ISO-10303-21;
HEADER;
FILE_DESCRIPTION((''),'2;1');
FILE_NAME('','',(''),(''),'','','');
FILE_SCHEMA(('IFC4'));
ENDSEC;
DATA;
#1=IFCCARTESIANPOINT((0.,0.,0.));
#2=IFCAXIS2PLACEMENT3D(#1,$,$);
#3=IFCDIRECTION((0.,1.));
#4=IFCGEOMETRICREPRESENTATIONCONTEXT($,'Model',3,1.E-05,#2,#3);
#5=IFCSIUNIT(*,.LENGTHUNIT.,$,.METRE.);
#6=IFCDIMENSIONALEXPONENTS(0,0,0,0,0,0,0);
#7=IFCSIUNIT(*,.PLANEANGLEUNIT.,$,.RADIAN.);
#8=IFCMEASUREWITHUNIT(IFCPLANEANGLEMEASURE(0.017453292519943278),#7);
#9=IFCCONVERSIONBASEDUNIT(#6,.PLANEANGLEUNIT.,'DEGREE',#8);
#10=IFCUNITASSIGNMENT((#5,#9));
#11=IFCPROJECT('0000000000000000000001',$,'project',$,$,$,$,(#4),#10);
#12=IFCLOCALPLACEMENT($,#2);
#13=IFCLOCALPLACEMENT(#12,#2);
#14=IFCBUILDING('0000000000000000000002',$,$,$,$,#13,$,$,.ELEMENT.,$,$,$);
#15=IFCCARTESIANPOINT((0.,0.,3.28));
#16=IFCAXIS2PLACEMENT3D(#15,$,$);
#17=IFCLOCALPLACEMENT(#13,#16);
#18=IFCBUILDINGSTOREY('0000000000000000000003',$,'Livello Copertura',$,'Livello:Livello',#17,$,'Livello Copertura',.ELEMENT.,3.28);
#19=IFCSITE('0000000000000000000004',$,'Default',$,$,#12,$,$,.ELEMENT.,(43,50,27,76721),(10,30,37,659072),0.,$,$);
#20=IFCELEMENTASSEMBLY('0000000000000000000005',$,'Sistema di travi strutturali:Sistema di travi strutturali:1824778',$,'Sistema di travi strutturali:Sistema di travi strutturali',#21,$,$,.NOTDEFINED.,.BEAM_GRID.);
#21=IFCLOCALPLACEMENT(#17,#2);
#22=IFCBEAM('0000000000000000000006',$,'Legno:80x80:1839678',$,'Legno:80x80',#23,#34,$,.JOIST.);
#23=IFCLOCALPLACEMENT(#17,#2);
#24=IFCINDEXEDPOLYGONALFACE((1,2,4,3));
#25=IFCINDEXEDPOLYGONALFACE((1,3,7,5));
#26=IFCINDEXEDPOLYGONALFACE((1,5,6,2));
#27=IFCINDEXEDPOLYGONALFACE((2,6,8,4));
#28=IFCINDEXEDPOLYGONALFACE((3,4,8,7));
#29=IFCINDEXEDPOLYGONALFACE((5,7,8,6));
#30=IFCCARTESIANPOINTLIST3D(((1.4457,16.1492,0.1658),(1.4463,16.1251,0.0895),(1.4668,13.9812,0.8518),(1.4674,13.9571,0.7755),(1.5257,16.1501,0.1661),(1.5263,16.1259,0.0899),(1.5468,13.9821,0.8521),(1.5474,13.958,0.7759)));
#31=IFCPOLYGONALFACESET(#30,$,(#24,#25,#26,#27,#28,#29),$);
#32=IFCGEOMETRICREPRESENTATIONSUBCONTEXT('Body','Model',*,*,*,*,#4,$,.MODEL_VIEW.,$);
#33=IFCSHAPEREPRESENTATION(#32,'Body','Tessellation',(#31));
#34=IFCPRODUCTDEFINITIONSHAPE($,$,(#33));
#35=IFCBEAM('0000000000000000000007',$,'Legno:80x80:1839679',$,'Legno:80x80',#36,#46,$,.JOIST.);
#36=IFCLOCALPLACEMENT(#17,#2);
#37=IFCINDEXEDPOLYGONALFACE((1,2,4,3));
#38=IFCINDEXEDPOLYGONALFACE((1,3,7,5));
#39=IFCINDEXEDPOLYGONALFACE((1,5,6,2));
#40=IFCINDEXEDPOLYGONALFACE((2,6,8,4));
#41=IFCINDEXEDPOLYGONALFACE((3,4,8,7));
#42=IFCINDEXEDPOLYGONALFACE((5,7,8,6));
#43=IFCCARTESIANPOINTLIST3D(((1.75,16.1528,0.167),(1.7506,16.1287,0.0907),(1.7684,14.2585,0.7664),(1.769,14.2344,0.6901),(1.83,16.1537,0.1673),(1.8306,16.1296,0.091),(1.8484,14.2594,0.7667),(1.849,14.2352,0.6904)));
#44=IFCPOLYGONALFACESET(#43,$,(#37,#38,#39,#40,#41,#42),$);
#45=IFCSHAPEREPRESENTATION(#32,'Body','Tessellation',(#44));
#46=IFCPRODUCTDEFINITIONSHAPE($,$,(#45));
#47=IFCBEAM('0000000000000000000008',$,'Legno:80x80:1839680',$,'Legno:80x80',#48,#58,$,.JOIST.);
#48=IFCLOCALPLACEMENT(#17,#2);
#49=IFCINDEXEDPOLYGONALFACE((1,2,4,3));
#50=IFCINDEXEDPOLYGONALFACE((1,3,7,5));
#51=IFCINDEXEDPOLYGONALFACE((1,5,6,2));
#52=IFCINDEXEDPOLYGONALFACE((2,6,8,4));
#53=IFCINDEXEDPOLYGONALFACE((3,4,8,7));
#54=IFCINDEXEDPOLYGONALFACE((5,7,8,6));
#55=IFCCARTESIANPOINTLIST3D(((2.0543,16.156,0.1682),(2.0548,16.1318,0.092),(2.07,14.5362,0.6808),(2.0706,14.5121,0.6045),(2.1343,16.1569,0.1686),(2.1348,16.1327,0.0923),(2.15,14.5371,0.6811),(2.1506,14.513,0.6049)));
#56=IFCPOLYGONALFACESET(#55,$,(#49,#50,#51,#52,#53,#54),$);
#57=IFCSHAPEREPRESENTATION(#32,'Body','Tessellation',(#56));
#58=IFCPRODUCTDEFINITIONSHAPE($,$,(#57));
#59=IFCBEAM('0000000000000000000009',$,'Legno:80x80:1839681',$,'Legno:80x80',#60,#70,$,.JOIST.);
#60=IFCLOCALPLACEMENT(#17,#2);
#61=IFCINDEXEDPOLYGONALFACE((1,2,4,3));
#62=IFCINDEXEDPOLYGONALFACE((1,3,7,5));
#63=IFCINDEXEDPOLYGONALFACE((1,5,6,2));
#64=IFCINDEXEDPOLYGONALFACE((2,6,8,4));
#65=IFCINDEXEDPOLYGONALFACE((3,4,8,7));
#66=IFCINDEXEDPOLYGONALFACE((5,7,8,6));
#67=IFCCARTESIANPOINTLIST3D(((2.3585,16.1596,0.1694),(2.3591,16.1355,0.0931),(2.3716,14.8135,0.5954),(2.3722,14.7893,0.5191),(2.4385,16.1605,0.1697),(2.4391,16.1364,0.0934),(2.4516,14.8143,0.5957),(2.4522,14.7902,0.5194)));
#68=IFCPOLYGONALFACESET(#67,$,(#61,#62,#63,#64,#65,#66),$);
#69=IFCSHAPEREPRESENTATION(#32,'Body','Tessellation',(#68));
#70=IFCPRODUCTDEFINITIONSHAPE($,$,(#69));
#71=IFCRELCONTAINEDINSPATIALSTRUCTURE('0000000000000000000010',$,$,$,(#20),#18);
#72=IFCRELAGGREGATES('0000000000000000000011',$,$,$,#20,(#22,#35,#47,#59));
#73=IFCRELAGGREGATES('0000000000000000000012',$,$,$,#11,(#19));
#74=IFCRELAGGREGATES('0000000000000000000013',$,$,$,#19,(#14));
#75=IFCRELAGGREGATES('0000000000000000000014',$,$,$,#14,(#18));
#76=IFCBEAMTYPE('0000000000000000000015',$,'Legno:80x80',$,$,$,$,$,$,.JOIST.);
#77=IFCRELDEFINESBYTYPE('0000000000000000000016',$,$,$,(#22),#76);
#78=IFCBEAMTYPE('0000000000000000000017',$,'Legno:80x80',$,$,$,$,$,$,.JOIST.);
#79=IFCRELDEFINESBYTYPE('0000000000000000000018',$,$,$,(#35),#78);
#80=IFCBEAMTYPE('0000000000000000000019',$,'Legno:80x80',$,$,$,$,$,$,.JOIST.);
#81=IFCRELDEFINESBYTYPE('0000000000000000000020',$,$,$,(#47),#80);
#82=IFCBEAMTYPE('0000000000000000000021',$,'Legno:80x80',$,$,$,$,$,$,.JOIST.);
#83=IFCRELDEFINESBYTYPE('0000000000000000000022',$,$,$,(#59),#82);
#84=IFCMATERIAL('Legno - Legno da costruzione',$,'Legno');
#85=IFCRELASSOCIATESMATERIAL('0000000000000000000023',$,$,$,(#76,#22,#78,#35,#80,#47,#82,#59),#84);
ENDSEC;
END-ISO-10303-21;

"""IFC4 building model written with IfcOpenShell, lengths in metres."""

from ifc_helpers import new_model, entity, si_unit, converted_unit, direction, frame, origin, place, context, subcontext, project, spatial, indexed_curve, outline, extrude, source, transform, mapped, material, type_object, type_shapes, element, aggregate, save


model = new_model("IFC4")

# Units and contexts
model_context = context("Model", 3, precision=1e-05, world=origin(), true_north=direction((0.0, 1.0)))
body_context = subcontext(model_context, "Body", "Model", "MODEL_VIEW")
ifc_project = project(units=[si_unit("LENGTHUNIT", "METRE"), converted_unit("PLANEANGLEUNIT", "DEGREE", entity("IfcPlaneAngleMeasure", 0.017453292519943278), si_unit("PLANEANGLEUNIT", "RADIAN"), dimensions=[0, 0, 0, 0, 0, 0, 0])], contexts=[model_context])

# Site, building, storey
site_placement = place(None, origin())
site = spatial("IfcSite", under=ifc_project, at=site_placement, Name="Default", CompositionType="ELEMENT", RefLatitude=(43, 50, 27, 76721), RefLongitude=(10, 30, 37, 659072), RefElevation=0.0)
building_placement = place(site_placement, origin())
building = spatial("IfcBuilding", under=site, at=building_placement, CompositionType="ELEMENT")
storey_placement = place(building_placement, frame((0.0, 0.0, 3.28)))
storey = spatial("IfcBuildingStorey", under=building, at=storey_placement, Name="Livello Copertura", ObjectType="Livello:Livello", LongName="Livello Copertura", CompositionType="ELEMENT", Elevation=3.28)

# Shared definitions
ifc_material = material(Name="Legno - Legno da costruzione", Category="Legno")

# Element assembly, beams
assembly_1_placement = place(storey_placement, origin())
assembly_1 = element("IfcElementAssembly", 1, at=assembly_1_placement, inside=storey, Name="Sistema di travi strutturali:Sistema di travi strutturali:1824778", ObjectType="Sistema di travi strutturali:Sistema di travi strutturali", AssemblyPlace="NOTDEFINED", PredefinedType="BEAM_GRID")
beam_type_1 = type_object("IfcBeamType", Name="Legno:80x80", PredefinedType="JOIST", material=ifc_material)
shared_shape_1 = source(origin(), body_context, "Body", "SweptSolid", [
    extrude(outline(indexed_curve([(-1.137, -0.04), (1.137, -0.04), (1.137, 0.04), (-1.137, 0.04), (-1.137, -0.04)], self_intersect=False)), frame((0.0, 0.0, -0.04), z_axis=(0.0, 0.0, 1.0), x_axis=(-1.0, 0.0, 0.0)), (0.0, 0.0, 1.0), 0.08),
])
type_shapes(beam_type_1, [shared_shape_1])
beam_1_placement = place(assembly_1_placement, frame((1.4965, 15.0536, 0.4708), z_axis=(-0.007187, 0.301619, 0.953402), x_axis=(0.009277, -0.953365, 0.301677)))
beam_1 = element("IfcBeam", 2, at=beam_1_placement, type_object=beam_type_1, material=ifc_material, Name="Legno:80x80:1839678", ObjectType="Legno:80x80", PredefinedType="JOIST", context=body_context, shape_type="MappedRepresentation", body=[
    mapped(shared_shape_1, transform((0.0, 0.0, 0.0), scale=1.0)),
])
beam_type_2 = type_object("IfcBeamType", Name="Legno:80x80", PredefinedType="JOIST", material=ifc_material)
shared_shape_2 = source(origin(), body_context, "Body", "SweptSolid", [
    extrude(outline(indexed_curve([(-0.9935, -0.04), (0.9935, -0.04), (0.9935, 0.04), (-0.9935, 0.04), (-0.9935, -0.04)], self_intersect=False)), frame((0.0, 0.0, -0.04), z_axis=(0.0, 0.0, 1.0), x_axis=(-1.0, 0.0, 0.0)), (0.0, 0.0, 1.0), 0.08),
])
type_shapes(beam_type_2, [shared_shape_2])
beam_2_placement = place(assembly_1_placement, frame((1.7995, 15.194, 0.4287), z_axis=(-0.007187, 0.301619, 0.953402), x_axis=(0.009277, -0.953365, 0.301677)))
beam_2 = element("IfcBeam", 3, at=beam_2_placement, type_object=beam_type_2, material=ifc_material, Name="Legno:80x80:1839679", ObjectType="Legno:80x80", PredefinedType="JOIST", context=body_context, shape_type="MappedRepresentation", body=[
    mapped(shared_shape_2, transform((0.0, 0.0, 0.0), scale=1.0)),
])
beam_type_3 = type_object("IfcBeamType", Name="Legno:80x80", PredefinedType="JOIST", material=ifc_material)
shared_shape_3 = source(origin(), body_context, "Body", "SweptSolid", [
    extrude(outline(indexed_curve([(-0.8495, -0.04), (0.8495, -0.04), (0.8495, 0.04), (-0.8495, 0.04), (-0.8495, -0.04)], self_intersect=False)), frame((0.0, 0.0, -0.04), z_axis=(0.0, 0.0, 1.0), x_axis=(-1.0, 0.0, 0.0)), (0.0, 0.0, 1.0), 0.08),
])
type_shapes(beam_type_3, [shared_shape_3])
beam_3_placement = place(assembly_1_placement, frame((2.1024, 15.3345, 0.3865), z_axis=(-0.007187, 0.301619, 0.953402), x_axis=(0.009277, -0.953365, 0.301677)))
beam_3 = element("IfcBeam", 4, at=beam_3_placement, type_object=beam_type_3, material=ifc_material, Name="Legno:80x80:1839680", ObjectType="Legno:80x80", PredefinedType="JOIST", context=body_context, shape_type="MappedRepresentation", body=[
    mapped(shared_shape_3, transform((0.0, 0.0, 0.0), scale=1.0)),
])
beam_type_4 = type_object("IfcBeamType", Name="Legno:80x80", PredefinedType="JOIST", material=ifc_material)
shared_shape_4 = source(origin(), body_context, "Body", "SweptSolid", [
    extrude(outline(indexed_curve([(-0.706, -0.04), (0.706, -0.04), (0.706, 0.04), (-0.706, 0.04), (-0.706, -0.04)], self_intersect=False)), frame((0.0, 0.0, -0.04), z_axis=(0.0, 0.0, 1.0), x_axis=(-1.0, 0.0, 0.0)), (0.0, 0.0, 1.0), 0.08),
])
type_shapes(beam_type_4, [shared_shape_4])
beam_4_placement = place(assembly_1_placement, frame((2.4054, 15.4749, 0.3444), z_axis=(-0.007187, 0.301619, 0.953402), x_axis=(0.009277, -0.953365, 0.301677)))
beam_4 = element("IfcBeam", 5, at=beam_4_placement, type_object=beam_type_4, material=ifc_material, Name="Legno:80x80:1839681", ObjectType="Legno:80x80", PredefinedType="JOIST", context=body_context, shape_type="MappedRepresentation", body=[
    mapped(shared_shape_4, transform((0.0, 0.0, 0.0), scale=1.0)),
])
aggregate(assembly_1, [beam_1, beam_2, beam_3, beam_4])

save(model, "model.ifc")
